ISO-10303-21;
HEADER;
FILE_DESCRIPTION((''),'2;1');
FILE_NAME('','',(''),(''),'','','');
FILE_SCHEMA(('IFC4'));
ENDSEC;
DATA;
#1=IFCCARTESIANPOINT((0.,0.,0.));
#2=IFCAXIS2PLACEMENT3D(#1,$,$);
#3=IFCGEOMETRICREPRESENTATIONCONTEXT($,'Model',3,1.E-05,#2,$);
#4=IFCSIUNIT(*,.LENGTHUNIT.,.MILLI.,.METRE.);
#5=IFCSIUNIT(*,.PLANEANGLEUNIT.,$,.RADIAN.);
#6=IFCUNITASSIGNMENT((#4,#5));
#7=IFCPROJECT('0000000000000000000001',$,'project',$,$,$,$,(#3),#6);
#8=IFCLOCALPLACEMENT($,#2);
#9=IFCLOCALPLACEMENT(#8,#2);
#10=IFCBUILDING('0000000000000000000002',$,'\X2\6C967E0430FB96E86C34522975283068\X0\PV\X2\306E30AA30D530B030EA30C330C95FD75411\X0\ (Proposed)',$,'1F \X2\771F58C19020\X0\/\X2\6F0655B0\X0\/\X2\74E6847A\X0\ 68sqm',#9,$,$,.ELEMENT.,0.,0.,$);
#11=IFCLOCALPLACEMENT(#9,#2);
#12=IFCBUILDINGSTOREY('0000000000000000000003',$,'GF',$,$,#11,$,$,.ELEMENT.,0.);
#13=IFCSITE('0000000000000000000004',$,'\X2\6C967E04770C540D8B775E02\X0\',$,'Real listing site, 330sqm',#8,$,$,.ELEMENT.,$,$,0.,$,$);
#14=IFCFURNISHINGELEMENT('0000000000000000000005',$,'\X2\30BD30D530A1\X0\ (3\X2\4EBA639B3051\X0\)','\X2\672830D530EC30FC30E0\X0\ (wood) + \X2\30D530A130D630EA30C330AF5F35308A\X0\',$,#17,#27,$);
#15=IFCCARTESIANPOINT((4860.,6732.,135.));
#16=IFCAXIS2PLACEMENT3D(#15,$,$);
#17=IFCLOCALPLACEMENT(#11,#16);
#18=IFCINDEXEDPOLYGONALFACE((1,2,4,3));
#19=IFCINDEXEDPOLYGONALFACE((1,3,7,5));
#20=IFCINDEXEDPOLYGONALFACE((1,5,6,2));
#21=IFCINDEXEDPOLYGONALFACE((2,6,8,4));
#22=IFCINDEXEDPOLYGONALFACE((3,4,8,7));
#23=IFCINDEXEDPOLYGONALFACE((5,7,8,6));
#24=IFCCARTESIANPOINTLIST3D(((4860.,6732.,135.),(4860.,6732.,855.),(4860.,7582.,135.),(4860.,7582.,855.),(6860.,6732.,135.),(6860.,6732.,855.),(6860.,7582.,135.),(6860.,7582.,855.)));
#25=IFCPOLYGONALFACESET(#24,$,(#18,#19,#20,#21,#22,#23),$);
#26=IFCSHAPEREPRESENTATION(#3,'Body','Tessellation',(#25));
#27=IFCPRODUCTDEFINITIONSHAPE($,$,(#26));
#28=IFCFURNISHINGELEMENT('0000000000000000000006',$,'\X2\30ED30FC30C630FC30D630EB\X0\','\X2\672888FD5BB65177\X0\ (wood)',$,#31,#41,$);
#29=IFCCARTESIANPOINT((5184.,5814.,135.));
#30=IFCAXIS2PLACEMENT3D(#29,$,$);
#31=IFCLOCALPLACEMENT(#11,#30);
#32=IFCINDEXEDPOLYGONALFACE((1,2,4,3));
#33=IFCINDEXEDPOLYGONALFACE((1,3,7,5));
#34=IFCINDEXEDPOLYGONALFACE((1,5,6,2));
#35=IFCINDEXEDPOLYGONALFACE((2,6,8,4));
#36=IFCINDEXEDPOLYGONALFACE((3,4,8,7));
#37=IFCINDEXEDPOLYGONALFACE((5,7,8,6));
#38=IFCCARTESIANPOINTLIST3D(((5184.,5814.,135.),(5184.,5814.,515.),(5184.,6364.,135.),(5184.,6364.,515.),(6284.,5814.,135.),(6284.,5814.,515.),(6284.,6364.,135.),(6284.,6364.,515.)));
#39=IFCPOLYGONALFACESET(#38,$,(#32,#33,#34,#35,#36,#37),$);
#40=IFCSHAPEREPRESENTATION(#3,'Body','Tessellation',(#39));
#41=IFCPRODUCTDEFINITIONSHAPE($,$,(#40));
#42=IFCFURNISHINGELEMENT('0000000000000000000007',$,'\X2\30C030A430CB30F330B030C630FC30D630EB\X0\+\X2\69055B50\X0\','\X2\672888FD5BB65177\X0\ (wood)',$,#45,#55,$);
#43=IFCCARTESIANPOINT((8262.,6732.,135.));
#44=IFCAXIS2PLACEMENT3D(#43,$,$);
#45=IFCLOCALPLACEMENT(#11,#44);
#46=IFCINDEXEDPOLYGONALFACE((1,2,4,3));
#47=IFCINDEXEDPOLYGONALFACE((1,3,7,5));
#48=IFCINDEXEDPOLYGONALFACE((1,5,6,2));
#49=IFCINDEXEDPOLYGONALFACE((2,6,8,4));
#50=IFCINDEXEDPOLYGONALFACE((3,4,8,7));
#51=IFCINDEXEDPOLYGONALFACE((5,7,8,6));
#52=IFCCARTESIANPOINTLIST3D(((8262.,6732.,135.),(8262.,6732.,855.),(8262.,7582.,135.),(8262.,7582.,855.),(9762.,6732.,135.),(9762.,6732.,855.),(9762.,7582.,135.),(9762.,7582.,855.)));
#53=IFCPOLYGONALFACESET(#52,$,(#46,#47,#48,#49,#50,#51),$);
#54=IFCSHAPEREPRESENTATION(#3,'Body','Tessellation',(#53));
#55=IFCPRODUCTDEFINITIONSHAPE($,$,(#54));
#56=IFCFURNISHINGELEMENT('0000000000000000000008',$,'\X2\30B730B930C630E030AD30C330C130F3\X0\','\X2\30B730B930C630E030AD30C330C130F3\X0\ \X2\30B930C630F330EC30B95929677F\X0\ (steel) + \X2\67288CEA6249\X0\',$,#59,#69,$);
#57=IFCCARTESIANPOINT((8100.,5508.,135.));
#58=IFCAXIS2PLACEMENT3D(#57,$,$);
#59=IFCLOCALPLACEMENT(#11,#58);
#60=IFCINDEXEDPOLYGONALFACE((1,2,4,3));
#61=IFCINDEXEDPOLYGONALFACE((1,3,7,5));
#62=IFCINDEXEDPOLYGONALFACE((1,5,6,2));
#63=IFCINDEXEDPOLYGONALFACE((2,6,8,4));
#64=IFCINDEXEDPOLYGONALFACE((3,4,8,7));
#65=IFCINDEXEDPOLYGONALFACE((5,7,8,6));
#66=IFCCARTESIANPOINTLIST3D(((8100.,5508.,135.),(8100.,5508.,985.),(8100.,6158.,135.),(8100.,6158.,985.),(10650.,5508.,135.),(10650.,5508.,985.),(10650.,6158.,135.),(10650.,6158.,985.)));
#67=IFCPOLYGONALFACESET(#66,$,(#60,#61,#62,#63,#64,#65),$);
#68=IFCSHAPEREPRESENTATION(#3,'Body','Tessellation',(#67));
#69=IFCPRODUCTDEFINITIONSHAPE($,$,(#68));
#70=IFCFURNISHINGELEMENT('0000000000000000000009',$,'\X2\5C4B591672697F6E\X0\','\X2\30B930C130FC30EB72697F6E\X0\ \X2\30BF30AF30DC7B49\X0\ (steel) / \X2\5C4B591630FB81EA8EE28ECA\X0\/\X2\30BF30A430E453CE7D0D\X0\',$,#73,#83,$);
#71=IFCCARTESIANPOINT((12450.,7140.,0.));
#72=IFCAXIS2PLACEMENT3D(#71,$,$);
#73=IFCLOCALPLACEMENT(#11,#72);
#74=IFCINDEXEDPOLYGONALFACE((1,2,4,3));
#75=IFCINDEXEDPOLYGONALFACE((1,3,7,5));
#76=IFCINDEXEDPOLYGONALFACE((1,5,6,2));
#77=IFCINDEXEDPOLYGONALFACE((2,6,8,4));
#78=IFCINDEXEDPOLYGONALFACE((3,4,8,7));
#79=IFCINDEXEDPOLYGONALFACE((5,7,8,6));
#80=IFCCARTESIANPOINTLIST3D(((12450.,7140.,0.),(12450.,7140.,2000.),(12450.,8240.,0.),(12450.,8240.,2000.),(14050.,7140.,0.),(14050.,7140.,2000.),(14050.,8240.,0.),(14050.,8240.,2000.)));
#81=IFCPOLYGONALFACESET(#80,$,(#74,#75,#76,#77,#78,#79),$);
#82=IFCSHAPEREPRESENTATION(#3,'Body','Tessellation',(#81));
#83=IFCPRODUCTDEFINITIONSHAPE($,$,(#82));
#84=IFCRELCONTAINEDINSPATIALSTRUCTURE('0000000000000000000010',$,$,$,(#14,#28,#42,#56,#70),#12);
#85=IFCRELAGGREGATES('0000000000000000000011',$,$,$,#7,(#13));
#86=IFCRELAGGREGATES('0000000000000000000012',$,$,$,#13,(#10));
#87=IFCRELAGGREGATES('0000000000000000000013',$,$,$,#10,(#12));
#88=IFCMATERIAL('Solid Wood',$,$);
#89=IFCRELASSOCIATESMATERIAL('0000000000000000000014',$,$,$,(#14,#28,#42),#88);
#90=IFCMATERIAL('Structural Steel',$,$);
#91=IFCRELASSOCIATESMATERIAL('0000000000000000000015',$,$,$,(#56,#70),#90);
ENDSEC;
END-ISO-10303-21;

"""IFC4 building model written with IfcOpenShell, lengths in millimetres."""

from ifc_helpers import new_model, si_unit, frame, frame_2d, origin, place, context, project, spatial, rectangle, extrude, material, element, save


model = new_model("IFC4")

# Units and contexts
model_context = context("Model", 3, precision=1e-05, world=origin())
ifc_project = project(units=[si_unit("LENGTHUNIT", "METRE", prefix="MILLI"), si_unit("PLANEANGLEUNIT", "RADIAN")], contexts=[model_context])

# Site, building, storey
site_placement = place(None, origin())
site = spatial("IfcSite", under=ifc_project, at=site_placement, Name="沖縄県名護市", ObjectType="Real listing site, 330sqm", CompositionType="ELEMENT", RefElevation=0.0)
building_placement = place(site_placement, origin())
building = spatial("IfcBuilding", under=site, at=building_placement, Name="沖縄・雨水利用とPVのオフグリッド志向 (Proposed)", ObjectType="1F 真壁造/漆喰/瓦葺 68sqm", CompositionType="ELEMENT", ElevationOfRefHeight=0.0, ElevationOfTerrain=0.0)
storey_placement = place(building_placement, origin())
storey = spatial("IfcBuildingStorey", under=building, at=storey_placement, Name="GF", CompositionType="ELEMENT", Elevation=0.0)

# Shared definitions
ifc_material_1 = material(Name="Solid Wood")

# Shared definitions
ifc_material_2 = material(Name="Structural Steel")

# Furnishing elements
furnishing_1_placement = place(storey_placement, frame((4860.0, 6732.0, 135.0)))
element("IfcFurnishingElement", 1, at=furnishing_1_placement, inside=storey, material=ifc_material_1, Name="ソファ (3人掛け)", Description="木フレーム (wood) + ファブリック張り", context=model_context, shape_type="SweptSolid", body=[
    extrude(rectangle(XDim=2000.0, YDim=850.0, at=frame_2d((1000.0, 425.0))), frame((4860.0, 6732.0, 135.0)), (0.0, 0.0, 1.0), 720.0),
])
furnishing_2_placement = place(storey_placement, frame((5184.0, 5814.0, 135.0)))
element("IfcFurnishingElement", 2, at=furnishing_2_placement, inside=storey, material=ifc_material_1, Name="ローテーブル", Description="木製家具 (wood)", context=model_context, shape_type="SweptSolid", body=[
    extrude(rectangle(XDim=1100.0, YDim=550.0, at=frame_2d((550.0, 275.0))), frame((5184.0, 5814.0, 135.0)), (0.0, 0.0, 1.0), 380.0),
])
furnishing_3_placement = place(storey_placement, frame((8262.0, 6732.0, 135.0)))
element("IfcFurnishingElement", 3, at=furnishing_3_placement, inside=storey, material=ifc_material_1, Name="ダイニングテーブル+椅子", Description="木製家具 (wood)", context=model_context, shape_type="SweptSolid", body=[
    extrude(rectangle(XDim=1500.0, YDim=850.0, at=frame_2d((750.0, 425.0))), frame((8262.0, 6732.0, 135.0)), (0.0, 0.0, 1.0), 720.0),
])
furnishing_4_placement = place(storey_placement, frame((8100.0, 5508.0, 135.0)))
element("IfcFurnishingElement", 4, at=furnishing_4_placement, inside=storey, material=ifc_material_2, Name="システムキッチン", Description="システムキッチン ステンレス天板 (steel) + 木質扉", context=model_context, shape_type="SweptSolid", body=[
    extrude(rectangle(XDim=2550.0, YDim=650.0, at=frame_2d((1275.0, 325.0))), frame((8100.0, 5508.0, 135.0)), (0.0, 0.0, 1.0), 850.0),
])
furnishing_5_placement = place(storey_placement, frame((12450.0, 7140.0, 0.0)))
element("IfcFurnishingElement", 5, at=furnishing_5_placement, inside=storey, material=ifc_material_2, Name="屋外物置", Description="スチール物置 タクボ等 (steel) / 屋外・自転車/タイヤ収納", context=model_context, shape_type="SweptSolid", body=[
    extrude(rectangle(XDim=1600.0, YDim=1100.0, at=frame_2d((800.0, 550.0))), frame((12450.0, 7140.0, 0.0)), (0.0, 0.0, 1.0), 2000.0),
])

save(model, "model.ifc")
